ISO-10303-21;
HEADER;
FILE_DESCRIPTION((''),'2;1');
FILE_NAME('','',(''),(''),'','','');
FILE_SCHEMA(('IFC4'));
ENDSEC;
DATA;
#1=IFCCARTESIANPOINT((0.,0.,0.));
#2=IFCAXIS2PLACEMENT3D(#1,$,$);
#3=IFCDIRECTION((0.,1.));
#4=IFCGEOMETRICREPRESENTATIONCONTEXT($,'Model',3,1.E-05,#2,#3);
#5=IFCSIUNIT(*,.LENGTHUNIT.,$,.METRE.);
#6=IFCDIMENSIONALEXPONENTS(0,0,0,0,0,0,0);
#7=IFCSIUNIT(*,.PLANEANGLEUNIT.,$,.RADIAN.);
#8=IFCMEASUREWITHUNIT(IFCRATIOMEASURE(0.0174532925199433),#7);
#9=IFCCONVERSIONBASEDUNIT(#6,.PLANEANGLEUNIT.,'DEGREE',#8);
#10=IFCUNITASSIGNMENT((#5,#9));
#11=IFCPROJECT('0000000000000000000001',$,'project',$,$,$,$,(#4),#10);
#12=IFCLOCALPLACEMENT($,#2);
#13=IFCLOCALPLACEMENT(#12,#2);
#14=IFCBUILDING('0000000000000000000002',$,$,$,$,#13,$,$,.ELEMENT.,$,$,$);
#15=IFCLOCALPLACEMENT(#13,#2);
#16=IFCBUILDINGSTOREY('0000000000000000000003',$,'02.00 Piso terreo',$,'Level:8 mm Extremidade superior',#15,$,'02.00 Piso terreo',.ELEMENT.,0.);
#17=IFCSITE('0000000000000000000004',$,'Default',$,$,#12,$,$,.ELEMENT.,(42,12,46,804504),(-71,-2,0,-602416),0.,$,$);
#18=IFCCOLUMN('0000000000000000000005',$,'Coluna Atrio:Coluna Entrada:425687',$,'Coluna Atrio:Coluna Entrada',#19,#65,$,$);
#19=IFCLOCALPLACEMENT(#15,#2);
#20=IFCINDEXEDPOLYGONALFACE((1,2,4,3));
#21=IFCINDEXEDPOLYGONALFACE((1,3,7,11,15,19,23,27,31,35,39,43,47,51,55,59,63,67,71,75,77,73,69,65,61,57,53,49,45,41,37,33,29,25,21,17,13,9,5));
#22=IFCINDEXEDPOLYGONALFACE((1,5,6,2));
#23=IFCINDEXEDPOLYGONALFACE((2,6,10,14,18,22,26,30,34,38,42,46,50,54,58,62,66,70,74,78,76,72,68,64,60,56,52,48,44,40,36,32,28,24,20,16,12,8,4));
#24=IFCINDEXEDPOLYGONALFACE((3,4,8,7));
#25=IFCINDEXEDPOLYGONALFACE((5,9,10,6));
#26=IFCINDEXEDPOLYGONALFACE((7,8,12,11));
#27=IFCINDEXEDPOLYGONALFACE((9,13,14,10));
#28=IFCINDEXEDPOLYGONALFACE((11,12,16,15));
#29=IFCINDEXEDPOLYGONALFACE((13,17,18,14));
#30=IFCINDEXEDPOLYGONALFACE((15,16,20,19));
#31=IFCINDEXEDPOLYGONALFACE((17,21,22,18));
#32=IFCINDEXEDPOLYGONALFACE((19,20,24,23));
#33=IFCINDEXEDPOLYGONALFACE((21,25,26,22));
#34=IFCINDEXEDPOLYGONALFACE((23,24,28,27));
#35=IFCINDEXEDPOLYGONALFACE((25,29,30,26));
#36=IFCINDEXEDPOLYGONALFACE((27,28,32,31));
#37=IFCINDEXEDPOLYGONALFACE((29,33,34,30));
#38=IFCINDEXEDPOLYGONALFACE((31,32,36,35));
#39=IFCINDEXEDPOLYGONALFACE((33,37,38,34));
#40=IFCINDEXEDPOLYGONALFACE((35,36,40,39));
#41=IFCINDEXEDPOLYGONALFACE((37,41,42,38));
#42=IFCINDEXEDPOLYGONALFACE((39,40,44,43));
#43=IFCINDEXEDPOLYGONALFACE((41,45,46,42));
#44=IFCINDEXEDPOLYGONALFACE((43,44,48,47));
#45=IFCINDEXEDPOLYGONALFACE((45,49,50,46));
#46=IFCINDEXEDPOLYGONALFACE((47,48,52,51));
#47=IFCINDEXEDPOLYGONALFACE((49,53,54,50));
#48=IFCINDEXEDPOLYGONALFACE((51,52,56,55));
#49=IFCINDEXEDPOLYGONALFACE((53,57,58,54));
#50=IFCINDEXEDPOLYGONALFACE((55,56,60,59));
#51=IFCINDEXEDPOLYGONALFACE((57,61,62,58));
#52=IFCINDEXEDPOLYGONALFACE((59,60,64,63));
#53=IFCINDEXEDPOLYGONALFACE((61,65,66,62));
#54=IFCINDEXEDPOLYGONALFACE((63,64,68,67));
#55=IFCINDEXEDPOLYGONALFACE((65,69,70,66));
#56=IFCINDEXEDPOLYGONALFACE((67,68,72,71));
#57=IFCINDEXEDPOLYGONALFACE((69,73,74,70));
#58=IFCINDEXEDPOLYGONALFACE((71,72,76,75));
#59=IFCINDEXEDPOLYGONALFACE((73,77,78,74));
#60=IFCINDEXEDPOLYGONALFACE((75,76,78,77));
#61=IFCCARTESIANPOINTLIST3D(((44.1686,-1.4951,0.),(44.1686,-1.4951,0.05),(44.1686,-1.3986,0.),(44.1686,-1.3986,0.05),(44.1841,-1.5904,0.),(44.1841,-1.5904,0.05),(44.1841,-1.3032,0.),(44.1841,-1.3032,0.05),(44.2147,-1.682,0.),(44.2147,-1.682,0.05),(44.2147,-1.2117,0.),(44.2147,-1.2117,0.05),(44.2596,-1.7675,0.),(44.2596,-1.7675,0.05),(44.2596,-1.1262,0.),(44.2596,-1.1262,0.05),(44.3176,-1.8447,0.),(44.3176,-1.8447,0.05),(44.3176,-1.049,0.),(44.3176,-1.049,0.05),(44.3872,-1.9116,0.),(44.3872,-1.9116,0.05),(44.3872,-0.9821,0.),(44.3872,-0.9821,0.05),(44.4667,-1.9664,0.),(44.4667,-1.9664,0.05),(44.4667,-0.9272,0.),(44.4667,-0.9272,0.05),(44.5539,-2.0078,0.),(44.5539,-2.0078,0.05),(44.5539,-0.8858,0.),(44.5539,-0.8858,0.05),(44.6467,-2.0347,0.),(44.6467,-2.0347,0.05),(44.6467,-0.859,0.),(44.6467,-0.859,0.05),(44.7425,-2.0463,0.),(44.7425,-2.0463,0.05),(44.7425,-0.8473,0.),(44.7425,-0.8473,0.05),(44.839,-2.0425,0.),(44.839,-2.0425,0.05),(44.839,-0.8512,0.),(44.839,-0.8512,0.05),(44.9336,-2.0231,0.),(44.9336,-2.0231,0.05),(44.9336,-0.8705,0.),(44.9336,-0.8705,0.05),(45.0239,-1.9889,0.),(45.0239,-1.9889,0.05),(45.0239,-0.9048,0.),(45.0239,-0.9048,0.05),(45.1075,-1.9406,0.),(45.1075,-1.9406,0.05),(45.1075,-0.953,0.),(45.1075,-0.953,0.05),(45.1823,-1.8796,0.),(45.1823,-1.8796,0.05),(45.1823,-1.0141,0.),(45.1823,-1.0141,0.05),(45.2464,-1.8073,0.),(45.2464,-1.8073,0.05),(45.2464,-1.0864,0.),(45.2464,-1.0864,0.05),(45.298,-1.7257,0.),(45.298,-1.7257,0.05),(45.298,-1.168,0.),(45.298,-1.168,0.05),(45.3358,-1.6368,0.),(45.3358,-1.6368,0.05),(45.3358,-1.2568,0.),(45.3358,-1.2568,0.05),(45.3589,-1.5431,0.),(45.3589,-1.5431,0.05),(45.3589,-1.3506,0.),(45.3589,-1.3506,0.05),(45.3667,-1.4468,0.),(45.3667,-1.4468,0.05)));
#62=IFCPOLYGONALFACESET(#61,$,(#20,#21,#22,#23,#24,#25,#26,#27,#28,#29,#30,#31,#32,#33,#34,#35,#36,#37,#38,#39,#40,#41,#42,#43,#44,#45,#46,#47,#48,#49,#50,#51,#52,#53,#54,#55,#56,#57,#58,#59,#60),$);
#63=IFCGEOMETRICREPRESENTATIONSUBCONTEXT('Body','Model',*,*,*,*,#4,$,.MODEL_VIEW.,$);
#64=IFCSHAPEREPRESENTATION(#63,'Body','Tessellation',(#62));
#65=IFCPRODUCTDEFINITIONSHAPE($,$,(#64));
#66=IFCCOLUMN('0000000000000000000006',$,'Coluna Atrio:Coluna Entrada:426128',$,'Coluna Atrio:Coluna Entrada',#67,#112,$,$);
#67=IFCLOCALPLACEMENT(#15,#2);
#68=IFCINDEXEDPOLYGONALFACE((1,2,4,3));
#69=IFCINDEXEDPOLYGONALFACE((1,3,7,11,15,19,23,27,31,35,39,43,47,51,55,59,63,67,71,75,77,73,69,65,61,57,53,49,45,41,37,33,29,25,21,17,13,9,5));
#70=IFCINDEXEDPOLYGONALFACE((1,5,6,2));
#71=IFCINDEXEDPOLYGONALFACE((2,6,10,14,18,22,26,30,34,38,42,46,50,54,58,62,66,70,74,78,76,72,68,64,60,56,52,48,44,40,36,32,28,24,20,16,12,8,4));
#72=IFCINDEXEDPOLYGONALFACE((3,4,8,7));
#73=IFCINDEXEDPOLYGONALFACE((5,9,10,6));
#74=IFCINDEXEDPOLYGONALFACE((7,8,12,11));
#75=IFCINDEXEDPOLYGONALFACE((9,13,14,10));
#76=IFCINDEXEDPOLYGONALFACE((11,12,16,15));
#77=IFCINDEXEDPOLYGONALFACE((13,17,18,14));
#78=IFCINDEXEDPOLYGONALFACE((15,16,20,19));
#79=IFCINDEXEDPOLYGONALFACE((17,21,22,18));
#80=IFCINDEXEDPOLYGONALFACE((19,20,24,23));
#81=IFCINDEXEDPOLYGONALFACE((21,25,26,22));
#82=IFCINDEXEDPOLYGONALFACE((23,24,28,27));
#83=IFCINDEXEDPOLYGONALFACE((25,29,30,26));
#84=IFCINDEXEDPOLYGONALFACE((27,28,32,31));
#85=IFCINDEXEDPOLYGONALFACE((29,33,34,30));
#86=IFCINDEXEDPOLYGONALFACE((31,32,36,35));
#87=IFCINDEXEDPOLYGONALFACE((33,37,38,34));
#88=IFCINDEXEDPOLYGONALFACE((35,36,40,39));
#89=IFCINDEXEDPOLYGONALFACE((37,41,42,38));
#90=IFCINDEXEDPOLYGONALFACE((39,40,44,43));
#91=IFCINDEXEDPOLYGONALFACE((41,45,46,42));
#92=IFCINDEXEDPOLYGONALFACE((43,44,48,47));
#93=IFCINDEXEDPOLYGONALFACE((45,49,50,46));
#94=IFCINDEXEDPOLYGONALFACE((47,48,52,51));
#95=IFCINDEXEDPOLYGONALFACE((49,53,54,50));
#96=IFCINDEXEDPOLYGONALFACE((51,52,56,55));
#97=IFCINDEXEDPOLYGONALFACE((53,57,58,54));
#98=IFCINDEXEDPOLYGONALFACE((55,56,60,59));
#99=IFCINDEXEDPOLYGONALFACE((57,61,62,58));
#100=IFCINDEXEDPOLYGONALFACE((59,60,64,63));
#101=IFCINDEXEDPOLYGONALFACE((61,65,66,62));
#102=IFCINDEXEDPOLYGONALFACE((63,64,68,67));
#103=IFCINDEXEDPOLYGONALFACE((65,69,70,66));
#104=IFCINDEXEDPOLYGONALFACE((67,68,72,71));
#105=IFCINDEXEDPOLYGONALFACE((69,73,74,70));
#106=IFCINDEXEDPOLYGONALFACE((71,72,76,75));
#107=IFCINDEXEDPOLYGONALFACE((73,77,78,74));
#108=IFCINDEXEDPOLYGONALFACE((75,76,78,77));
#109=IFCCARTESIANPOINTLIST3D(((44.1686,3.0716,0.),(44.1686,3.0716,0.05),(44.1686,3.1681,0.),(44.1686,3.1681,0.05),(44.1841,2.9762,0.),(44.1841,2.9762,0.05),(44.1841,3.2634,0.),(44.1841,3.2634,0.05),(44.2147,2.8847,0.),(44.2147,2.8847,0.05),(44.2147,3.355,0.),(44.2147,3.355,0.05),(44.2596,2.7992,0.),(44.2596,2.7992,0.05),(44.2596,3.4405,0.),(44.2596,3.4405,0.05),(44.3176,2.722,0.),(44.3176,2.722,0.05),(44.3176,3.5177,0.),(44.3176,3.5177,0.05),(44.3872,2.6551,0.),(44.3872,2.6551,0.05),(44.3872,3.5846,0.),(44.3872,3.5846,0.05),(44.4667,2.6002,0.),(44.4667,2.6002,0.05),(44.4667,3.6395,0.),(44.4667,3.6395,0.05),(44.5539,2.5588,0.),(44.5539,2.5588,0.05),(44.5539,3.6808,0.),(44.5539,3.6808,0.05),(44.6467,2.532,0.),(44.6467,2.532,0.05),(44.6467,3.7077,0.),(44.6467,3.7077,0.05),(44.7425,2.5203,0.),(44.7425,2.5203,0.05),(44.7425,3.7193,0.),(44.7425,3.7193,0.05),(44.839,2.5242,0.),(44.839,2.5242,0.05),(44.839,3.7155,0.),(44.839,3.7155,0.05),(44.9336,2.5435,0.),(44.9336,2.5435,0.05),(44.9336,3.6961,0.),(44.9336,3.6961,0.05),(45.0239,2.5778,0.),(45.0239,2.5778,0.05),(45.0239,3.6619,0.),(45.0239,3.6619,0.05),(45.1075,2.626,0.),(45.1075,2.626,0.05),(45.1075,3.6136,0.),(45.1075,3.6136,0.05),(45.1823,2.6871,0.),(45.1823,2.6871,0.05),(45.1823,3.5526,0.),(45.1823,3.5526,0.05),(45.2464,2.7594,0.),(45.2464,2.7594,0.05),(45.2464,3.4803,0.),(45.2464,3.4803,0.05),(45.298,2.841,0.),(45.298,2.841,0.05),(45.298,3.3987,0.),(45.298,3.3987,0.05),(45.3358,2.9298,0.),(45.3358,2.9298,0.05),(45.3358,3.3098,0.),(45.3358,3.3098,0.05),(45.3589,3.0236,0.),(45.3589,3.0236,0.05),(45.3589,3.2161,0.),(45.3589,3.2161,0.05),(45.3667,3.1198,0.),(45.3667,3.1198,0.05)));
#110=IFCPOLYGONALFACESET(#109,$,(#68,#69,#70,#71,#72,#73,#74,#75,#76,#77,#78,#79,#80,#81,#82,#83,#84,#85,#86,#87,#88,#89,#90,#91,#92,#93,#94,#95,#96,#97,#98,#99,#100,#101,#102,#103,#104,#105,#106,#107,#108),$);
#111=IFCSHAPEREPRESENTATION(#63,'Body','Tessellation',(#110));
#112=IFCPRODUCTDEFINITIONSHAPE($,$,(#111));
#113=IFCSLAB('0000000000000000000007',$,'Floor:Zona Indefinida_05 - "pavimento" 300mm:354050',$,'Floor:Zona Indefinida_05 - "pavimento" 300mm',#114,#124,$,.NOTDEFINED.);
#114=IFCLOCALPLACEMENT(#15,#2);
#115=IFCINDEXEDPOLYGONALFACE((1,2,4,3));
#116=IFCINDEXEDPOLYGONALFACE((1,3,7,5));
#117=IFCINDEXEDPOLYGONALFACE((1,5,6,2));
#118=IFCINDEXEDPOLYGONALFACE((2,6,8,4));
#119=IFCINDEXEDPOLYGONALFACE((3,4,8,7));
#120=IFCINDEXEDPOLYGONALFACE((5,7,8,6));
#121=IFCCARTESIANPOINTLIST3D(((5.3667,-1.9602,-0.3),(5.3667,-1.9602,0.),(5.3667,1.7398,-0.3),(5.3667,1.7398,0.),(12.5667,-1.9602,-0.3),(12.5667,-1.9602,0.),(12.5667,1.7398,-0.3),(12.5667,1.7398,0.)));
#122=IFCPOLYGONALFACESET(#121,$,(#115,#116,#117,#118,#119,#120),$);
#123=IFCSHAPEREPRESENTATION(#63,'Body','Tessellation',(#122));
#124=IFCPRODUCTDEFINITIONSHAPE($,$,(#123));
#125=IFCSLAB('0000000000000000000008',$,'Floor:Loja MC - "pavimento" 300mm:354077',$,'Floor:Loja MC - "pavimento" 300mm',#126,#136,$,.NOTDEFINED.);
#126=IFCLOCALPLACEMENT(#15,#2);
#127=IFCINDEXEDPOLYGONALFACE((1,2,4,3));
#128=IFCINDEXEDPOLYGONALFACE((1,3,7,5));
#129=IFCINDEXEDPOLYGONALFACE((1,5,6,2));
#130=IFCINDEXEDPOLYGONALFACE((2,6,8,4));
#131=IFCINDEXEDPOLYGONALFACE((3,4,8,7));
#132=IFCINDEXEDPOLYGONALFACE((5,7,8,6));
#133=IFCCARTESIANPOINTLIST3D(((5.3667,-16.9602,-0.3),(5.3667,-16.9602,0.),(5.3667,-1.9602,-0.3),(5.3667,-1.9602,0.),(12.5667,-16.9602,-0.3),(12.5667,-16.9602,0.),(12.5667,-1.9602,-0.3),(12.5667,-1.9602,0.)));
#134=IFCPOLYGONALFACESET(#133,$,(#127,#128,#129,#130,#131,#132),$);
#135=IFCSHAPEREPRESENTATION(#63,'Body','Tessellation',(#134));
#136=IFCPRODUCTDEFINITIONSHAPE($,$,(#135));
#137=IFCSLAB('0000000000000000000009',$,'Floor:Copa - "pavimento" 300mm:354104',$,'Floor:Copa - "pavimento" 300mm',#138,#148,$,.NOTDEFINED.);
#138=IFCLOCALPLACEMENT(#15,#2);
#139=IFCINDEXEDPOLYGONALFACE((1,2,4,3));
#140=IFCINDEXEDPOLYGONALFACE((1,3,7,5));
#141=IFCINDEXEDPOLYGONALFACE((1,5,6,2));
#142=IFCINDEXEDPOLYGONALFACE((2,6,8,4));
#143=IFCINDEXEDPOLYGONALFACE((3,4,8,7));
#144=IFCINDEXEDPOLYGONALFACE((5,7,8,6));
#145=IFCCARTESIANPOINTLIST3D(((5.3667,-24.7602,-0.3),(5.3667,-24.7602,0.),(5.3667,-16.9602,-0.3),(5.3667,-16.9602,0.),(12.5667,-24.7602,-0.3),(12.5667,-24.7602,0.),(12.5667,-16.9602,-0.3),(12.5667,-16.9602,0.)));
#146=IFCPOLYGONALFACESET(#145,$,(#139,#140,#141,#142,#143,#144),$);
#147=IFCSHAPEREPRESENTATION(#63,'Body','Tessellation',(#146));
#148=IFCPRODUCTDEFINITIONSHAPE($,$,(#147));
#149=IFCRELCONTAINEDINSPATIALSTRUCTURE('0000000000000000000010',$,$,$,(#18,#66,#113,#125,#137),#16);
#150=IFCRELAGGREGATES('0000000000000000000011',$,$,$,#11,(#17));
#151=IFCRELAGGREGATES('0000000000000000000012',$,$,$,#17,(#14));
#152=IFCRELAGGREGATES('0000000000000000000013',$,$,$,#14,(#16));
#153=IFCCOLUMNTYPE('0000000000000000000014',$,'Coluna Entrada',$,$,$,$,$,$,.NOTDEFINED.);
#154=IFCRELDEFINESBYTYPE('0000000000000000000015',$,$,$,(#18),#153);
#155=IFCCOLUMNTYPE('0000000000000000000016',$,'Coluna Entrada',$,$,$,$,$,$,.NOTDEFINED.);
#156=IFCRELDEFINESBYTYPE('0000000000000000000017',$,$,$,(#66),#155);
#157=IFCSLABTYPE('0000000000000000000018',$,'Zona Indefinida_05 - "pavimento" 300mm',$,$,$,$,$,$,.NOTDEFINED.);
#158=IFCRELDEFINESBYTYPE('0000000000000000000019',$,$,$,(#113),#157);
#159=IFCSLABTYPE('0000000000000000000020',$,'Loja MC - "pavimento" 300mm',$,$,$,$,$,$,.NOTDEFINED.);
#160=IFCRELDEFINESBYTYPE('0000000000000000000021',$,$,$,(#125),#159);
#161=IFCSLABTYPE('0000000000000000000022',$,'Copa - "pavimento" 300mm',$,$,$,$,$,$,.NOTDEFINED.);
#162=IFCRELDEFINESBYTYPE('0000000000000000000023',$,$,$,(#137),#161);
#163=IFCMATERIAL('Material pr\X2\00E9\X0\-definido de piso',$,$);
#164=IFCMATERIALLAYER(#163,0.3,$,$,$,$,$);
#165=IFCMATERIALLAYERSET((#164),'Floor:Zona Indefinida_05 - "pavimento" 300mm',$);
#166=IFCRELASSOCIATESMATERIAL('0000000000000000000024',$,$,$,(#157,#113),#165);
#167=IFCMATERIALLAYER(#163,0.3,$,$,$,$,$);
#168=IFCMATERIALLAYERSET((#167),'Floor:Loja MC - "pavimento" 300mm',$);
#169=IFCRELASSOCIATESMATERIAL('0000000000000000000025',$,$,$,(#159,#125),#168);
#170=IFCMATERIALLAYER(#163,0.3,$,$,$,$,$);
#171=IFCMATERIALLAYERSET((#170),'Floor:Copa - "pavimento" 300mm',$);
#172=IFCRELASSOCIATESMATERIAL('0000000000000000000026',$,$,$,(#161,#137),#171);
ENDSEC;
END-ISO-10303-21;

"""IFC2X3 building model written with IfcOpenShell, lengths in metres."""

from ifc_helpers import new_model, entity, si_unit, converted_unit, direction, frame, frame_2d, origin, origin_2d_with_axis, place, context, subcontext, project, spatial, rectangle, circle, extrude, source, transform, mapped, material, layer, layer_set, layer_usage, type_object, type_shapes, element, save


model = new_model("IFC2X3")

# Units and contexts
model_context = context("Model", 3, precision=1e-05, world=origin(), true_north=direction((0.0, 1.0)))
body_context = subcontext(model_context, "Body", "Model", "MODEL_VIEW")
ifc_project = project(units=[si_unit("LENGTHUNIT", "METRE"), converted_unit("PLANEANGLEUNIT", "DEGREE", entity("IfcRatioMeasure", 0.0174532925199433), si_unit("PLANEANGLEUNIT", "RADIAN"), dimensions=[0, 0, 0, 0, 0, 0, 0])], contexts=[model_context])

# Site, building, storey
site_placement = place(None, origin())
site = spatial("IfcSite", under=ifc_project, at=site_placement, Name="Default", CompositionType="ELEMENT", RefLatitude=(42, 12, 46, 804504), RefLongitude=(-71, -2, 0, -602416), RefElevation=0.0)
building_placement = place(site_placement, origin())
building = spatial("IfcBuilding", under=site, at=building_placement, CompositionType="ELEMENT")
storey_placement = place(building_placement, origin())
storey = spatial("IfcBuildingStorey", under=building, at=storey_placement, Name="02.00 Piso terreo", ObjectType="Level:8 mm Extremidade superior", LongName="02.00 Piso terreo", CompositionType="ELEMENT", Elevation=0.0)

# Columns
column_type_1 = type_object("IfcColumnType", Name="Coluna Entrada", PredefinedType="NOTDEFINED")
shared_shape_1 = source(origin(), body_context, "Body", "SweptSolid", [
    extrude(circle(Radius=0.6, at=frame_2d((0.0, 0.0), x_axis=(1.0, 0.0))), origin(), (0.0, 0.0, 1.0), 0.05),
])
type_shapes(column_type_1, [shared_shape_1])
column_1_placement = place(storey_placement, frame((44.7667, -1.4468, 0.0)))
element("IfcColumn", 1, at=column_1_placement, inside=storey, type_object=column_type_1, Name="Coluna Atrio:Coluna Entrada:425687", ObjectType="Coluna Atrio:Coluna Entrada", context=body_context, shape_type="MappedRepresentation", body=[
    mapped(shared_shape_1, transform((0.0, 0.0, 0.0), scale=1.0)),
])
column_type_2 = type_object("IfcColumnType", Name="Coluna Entrada", PredefinedType="NOTDEFINED")
shared_shape_2 = source(origin(), body_context, "Body", "SweptSolid", [
    extrude(circle(Radius=0.6, at=frame_2d((0.0, 0.0), x_axis=(1.0, 0.0))), origin(), (0.0, 0.0, 1.0), 0.05),
])
type_shapes(column_type_2, [shared_shape_2])
column_2_placement = place(storey_placement, frame((44.7667, 3.1198, 0.0)))
element("IfcColumn", 2, at=column_2_placement, inside=storey, type_object=column_type_2, Name="Coluna Atrio:Coluna Entrada:426128", ObjectType="Coluna Atrio:Coluna Entrada", context=body_context, shape_type="MappedRepresentation", body=[
    mapped(shared_shape_2, transform((0.0, 0.0, 0.0), scale=1.0)),
])

# Slabs
ifc_material_1 = material(Name="Material pré-definido de piso")
ifc_layer_1 = layer(ifc_material_1, 0.3)
ifc_layer_set_1 = layer_set([ifc_layer_1], Name="Floor:Zona Indefinida_05 - \"pavimento\" 300mm")
ifc_layer_usage_1 = layer_usage(ifc_layer_set_1, "AXIS3", "POSITIVE", 0.0)
slab_type_1 = type_object("IfcSlabType", Name="Zona Indefinida_05 - \"pavimento\" 300mm", PredefinedType="NOTDEFINED", material=ifc_layer_set_1)
slab_1_placement = place(storey_placement, origin())
element("IfcSlab", 3, at=slab_1_placement, inside=storey, type_object=slab_type_1, material=ifc_layer_usage_1, Name="Floor:Zona Indefinida_05 - \"pavimento\" 300mm:354050", ObjectType="Floor:Zona Indefinida_05 - \"pavimento\" 300mm", PredefinedType="NOTDEFINED", context=body_context, shape_type="SweptSolid", body=[
    extrude(rectangle(XDim=3.7, YDim=7.2, at=origin_2d_with_axis()), frame((8.9667, -0.1102, 0.0), z_axis=(0.0, 0.0, -1.0), x_axis=(0.0, 1.0, 0.0)), (0.0, 0.0, 1.0), 0.3),
])
ifc_layer_2 = layer(ifc_material_1, 0.3)
ifc_layer_set_2 = layer_set([ifc_layer_2], Name="Floor:Loja MC - \"pavimento\" 300mm")
ifc_layer_usage_2 = layer_usage(ifc_layer_set_2, "AXIS3", "POSITIVE", 0.0)
slab_type_2 = type_object("IfcSlabType", Name="Loja MC - \"pavimento\" 300mm", PredefinedType="NOTDEFINED", material=ifc_layer_set_2)
slab_2_placement = place(storey_placement, origin())
element("IfcSlab", 4, at=slab_2_placement, inside=storey, type_object=slab_type_2, material=ifc_layer_usage_2, Name="Floor:Loja MC - \"pavimento\" 300mm:354077", ObjectType="Floor:Loja MC - \"pavimento\" 300mm", PredefinedType="NOTDEFINED", context=body_context, shape_type="SweptSolid", body=[
    extrude(rectangle(XDim=15.0, YDim=7.2, at=frame_2d((0.0, 0.0), x_axis=(1.0, 0.0))), frame((8.9667, -9.4602, 0.0), z_axis=(0.0, 0.0, -1.0), x_axis=(0.0, 1.0, 0.0)), (0.0, 0.0, 1.0), 0.3),
])
ifc_layer_3 = layer(ifc_material_1, 0.3)
ifc_layer_set_3 = layer_set([ifc_layer_3], Name="Floor:Copa - \"pavimento\" 300mm")
ifc_layer_usage_3 = layer_usage(ifc_layer_set_3, "AXIS3", "POSITIVE", 0.0)
slab_type_3 = type_object("IfcSlabType", Name="Copa - \"pavimento\" 300mm", PredefinedType="NOTDEFINED", material=ifc_layer_set_3)
slab_3_placement = place(storey_placement, origin())
element("IfcSlab", 5, at=slab_3_placement, inside=storey, type_object=slab_type_3, material=ifc_layer_usage_3, Name="Floor:Copa - \"pavimento\" 300mm:354104", ObjectType="Floor:Copa - \"pavimento\" 300mm", PredefinedType="NOTDEFINED", context=body_context, shape_type="SweptSolid", body=[
    extrude(rectangle(XDim=7.8, YDim=7.2, at=frame_2d((0.0, 0.0), x_axis=(1.0, 0.0))), frame((8.9667, -20.8602, 0.0), z_axis=(0.0, 0.0, -1.0), x_axis=(0.0, 1.0, 0.0)), (0.0, 0.0, 1.0), 0.3),
])

save(model, "model.ifc")
